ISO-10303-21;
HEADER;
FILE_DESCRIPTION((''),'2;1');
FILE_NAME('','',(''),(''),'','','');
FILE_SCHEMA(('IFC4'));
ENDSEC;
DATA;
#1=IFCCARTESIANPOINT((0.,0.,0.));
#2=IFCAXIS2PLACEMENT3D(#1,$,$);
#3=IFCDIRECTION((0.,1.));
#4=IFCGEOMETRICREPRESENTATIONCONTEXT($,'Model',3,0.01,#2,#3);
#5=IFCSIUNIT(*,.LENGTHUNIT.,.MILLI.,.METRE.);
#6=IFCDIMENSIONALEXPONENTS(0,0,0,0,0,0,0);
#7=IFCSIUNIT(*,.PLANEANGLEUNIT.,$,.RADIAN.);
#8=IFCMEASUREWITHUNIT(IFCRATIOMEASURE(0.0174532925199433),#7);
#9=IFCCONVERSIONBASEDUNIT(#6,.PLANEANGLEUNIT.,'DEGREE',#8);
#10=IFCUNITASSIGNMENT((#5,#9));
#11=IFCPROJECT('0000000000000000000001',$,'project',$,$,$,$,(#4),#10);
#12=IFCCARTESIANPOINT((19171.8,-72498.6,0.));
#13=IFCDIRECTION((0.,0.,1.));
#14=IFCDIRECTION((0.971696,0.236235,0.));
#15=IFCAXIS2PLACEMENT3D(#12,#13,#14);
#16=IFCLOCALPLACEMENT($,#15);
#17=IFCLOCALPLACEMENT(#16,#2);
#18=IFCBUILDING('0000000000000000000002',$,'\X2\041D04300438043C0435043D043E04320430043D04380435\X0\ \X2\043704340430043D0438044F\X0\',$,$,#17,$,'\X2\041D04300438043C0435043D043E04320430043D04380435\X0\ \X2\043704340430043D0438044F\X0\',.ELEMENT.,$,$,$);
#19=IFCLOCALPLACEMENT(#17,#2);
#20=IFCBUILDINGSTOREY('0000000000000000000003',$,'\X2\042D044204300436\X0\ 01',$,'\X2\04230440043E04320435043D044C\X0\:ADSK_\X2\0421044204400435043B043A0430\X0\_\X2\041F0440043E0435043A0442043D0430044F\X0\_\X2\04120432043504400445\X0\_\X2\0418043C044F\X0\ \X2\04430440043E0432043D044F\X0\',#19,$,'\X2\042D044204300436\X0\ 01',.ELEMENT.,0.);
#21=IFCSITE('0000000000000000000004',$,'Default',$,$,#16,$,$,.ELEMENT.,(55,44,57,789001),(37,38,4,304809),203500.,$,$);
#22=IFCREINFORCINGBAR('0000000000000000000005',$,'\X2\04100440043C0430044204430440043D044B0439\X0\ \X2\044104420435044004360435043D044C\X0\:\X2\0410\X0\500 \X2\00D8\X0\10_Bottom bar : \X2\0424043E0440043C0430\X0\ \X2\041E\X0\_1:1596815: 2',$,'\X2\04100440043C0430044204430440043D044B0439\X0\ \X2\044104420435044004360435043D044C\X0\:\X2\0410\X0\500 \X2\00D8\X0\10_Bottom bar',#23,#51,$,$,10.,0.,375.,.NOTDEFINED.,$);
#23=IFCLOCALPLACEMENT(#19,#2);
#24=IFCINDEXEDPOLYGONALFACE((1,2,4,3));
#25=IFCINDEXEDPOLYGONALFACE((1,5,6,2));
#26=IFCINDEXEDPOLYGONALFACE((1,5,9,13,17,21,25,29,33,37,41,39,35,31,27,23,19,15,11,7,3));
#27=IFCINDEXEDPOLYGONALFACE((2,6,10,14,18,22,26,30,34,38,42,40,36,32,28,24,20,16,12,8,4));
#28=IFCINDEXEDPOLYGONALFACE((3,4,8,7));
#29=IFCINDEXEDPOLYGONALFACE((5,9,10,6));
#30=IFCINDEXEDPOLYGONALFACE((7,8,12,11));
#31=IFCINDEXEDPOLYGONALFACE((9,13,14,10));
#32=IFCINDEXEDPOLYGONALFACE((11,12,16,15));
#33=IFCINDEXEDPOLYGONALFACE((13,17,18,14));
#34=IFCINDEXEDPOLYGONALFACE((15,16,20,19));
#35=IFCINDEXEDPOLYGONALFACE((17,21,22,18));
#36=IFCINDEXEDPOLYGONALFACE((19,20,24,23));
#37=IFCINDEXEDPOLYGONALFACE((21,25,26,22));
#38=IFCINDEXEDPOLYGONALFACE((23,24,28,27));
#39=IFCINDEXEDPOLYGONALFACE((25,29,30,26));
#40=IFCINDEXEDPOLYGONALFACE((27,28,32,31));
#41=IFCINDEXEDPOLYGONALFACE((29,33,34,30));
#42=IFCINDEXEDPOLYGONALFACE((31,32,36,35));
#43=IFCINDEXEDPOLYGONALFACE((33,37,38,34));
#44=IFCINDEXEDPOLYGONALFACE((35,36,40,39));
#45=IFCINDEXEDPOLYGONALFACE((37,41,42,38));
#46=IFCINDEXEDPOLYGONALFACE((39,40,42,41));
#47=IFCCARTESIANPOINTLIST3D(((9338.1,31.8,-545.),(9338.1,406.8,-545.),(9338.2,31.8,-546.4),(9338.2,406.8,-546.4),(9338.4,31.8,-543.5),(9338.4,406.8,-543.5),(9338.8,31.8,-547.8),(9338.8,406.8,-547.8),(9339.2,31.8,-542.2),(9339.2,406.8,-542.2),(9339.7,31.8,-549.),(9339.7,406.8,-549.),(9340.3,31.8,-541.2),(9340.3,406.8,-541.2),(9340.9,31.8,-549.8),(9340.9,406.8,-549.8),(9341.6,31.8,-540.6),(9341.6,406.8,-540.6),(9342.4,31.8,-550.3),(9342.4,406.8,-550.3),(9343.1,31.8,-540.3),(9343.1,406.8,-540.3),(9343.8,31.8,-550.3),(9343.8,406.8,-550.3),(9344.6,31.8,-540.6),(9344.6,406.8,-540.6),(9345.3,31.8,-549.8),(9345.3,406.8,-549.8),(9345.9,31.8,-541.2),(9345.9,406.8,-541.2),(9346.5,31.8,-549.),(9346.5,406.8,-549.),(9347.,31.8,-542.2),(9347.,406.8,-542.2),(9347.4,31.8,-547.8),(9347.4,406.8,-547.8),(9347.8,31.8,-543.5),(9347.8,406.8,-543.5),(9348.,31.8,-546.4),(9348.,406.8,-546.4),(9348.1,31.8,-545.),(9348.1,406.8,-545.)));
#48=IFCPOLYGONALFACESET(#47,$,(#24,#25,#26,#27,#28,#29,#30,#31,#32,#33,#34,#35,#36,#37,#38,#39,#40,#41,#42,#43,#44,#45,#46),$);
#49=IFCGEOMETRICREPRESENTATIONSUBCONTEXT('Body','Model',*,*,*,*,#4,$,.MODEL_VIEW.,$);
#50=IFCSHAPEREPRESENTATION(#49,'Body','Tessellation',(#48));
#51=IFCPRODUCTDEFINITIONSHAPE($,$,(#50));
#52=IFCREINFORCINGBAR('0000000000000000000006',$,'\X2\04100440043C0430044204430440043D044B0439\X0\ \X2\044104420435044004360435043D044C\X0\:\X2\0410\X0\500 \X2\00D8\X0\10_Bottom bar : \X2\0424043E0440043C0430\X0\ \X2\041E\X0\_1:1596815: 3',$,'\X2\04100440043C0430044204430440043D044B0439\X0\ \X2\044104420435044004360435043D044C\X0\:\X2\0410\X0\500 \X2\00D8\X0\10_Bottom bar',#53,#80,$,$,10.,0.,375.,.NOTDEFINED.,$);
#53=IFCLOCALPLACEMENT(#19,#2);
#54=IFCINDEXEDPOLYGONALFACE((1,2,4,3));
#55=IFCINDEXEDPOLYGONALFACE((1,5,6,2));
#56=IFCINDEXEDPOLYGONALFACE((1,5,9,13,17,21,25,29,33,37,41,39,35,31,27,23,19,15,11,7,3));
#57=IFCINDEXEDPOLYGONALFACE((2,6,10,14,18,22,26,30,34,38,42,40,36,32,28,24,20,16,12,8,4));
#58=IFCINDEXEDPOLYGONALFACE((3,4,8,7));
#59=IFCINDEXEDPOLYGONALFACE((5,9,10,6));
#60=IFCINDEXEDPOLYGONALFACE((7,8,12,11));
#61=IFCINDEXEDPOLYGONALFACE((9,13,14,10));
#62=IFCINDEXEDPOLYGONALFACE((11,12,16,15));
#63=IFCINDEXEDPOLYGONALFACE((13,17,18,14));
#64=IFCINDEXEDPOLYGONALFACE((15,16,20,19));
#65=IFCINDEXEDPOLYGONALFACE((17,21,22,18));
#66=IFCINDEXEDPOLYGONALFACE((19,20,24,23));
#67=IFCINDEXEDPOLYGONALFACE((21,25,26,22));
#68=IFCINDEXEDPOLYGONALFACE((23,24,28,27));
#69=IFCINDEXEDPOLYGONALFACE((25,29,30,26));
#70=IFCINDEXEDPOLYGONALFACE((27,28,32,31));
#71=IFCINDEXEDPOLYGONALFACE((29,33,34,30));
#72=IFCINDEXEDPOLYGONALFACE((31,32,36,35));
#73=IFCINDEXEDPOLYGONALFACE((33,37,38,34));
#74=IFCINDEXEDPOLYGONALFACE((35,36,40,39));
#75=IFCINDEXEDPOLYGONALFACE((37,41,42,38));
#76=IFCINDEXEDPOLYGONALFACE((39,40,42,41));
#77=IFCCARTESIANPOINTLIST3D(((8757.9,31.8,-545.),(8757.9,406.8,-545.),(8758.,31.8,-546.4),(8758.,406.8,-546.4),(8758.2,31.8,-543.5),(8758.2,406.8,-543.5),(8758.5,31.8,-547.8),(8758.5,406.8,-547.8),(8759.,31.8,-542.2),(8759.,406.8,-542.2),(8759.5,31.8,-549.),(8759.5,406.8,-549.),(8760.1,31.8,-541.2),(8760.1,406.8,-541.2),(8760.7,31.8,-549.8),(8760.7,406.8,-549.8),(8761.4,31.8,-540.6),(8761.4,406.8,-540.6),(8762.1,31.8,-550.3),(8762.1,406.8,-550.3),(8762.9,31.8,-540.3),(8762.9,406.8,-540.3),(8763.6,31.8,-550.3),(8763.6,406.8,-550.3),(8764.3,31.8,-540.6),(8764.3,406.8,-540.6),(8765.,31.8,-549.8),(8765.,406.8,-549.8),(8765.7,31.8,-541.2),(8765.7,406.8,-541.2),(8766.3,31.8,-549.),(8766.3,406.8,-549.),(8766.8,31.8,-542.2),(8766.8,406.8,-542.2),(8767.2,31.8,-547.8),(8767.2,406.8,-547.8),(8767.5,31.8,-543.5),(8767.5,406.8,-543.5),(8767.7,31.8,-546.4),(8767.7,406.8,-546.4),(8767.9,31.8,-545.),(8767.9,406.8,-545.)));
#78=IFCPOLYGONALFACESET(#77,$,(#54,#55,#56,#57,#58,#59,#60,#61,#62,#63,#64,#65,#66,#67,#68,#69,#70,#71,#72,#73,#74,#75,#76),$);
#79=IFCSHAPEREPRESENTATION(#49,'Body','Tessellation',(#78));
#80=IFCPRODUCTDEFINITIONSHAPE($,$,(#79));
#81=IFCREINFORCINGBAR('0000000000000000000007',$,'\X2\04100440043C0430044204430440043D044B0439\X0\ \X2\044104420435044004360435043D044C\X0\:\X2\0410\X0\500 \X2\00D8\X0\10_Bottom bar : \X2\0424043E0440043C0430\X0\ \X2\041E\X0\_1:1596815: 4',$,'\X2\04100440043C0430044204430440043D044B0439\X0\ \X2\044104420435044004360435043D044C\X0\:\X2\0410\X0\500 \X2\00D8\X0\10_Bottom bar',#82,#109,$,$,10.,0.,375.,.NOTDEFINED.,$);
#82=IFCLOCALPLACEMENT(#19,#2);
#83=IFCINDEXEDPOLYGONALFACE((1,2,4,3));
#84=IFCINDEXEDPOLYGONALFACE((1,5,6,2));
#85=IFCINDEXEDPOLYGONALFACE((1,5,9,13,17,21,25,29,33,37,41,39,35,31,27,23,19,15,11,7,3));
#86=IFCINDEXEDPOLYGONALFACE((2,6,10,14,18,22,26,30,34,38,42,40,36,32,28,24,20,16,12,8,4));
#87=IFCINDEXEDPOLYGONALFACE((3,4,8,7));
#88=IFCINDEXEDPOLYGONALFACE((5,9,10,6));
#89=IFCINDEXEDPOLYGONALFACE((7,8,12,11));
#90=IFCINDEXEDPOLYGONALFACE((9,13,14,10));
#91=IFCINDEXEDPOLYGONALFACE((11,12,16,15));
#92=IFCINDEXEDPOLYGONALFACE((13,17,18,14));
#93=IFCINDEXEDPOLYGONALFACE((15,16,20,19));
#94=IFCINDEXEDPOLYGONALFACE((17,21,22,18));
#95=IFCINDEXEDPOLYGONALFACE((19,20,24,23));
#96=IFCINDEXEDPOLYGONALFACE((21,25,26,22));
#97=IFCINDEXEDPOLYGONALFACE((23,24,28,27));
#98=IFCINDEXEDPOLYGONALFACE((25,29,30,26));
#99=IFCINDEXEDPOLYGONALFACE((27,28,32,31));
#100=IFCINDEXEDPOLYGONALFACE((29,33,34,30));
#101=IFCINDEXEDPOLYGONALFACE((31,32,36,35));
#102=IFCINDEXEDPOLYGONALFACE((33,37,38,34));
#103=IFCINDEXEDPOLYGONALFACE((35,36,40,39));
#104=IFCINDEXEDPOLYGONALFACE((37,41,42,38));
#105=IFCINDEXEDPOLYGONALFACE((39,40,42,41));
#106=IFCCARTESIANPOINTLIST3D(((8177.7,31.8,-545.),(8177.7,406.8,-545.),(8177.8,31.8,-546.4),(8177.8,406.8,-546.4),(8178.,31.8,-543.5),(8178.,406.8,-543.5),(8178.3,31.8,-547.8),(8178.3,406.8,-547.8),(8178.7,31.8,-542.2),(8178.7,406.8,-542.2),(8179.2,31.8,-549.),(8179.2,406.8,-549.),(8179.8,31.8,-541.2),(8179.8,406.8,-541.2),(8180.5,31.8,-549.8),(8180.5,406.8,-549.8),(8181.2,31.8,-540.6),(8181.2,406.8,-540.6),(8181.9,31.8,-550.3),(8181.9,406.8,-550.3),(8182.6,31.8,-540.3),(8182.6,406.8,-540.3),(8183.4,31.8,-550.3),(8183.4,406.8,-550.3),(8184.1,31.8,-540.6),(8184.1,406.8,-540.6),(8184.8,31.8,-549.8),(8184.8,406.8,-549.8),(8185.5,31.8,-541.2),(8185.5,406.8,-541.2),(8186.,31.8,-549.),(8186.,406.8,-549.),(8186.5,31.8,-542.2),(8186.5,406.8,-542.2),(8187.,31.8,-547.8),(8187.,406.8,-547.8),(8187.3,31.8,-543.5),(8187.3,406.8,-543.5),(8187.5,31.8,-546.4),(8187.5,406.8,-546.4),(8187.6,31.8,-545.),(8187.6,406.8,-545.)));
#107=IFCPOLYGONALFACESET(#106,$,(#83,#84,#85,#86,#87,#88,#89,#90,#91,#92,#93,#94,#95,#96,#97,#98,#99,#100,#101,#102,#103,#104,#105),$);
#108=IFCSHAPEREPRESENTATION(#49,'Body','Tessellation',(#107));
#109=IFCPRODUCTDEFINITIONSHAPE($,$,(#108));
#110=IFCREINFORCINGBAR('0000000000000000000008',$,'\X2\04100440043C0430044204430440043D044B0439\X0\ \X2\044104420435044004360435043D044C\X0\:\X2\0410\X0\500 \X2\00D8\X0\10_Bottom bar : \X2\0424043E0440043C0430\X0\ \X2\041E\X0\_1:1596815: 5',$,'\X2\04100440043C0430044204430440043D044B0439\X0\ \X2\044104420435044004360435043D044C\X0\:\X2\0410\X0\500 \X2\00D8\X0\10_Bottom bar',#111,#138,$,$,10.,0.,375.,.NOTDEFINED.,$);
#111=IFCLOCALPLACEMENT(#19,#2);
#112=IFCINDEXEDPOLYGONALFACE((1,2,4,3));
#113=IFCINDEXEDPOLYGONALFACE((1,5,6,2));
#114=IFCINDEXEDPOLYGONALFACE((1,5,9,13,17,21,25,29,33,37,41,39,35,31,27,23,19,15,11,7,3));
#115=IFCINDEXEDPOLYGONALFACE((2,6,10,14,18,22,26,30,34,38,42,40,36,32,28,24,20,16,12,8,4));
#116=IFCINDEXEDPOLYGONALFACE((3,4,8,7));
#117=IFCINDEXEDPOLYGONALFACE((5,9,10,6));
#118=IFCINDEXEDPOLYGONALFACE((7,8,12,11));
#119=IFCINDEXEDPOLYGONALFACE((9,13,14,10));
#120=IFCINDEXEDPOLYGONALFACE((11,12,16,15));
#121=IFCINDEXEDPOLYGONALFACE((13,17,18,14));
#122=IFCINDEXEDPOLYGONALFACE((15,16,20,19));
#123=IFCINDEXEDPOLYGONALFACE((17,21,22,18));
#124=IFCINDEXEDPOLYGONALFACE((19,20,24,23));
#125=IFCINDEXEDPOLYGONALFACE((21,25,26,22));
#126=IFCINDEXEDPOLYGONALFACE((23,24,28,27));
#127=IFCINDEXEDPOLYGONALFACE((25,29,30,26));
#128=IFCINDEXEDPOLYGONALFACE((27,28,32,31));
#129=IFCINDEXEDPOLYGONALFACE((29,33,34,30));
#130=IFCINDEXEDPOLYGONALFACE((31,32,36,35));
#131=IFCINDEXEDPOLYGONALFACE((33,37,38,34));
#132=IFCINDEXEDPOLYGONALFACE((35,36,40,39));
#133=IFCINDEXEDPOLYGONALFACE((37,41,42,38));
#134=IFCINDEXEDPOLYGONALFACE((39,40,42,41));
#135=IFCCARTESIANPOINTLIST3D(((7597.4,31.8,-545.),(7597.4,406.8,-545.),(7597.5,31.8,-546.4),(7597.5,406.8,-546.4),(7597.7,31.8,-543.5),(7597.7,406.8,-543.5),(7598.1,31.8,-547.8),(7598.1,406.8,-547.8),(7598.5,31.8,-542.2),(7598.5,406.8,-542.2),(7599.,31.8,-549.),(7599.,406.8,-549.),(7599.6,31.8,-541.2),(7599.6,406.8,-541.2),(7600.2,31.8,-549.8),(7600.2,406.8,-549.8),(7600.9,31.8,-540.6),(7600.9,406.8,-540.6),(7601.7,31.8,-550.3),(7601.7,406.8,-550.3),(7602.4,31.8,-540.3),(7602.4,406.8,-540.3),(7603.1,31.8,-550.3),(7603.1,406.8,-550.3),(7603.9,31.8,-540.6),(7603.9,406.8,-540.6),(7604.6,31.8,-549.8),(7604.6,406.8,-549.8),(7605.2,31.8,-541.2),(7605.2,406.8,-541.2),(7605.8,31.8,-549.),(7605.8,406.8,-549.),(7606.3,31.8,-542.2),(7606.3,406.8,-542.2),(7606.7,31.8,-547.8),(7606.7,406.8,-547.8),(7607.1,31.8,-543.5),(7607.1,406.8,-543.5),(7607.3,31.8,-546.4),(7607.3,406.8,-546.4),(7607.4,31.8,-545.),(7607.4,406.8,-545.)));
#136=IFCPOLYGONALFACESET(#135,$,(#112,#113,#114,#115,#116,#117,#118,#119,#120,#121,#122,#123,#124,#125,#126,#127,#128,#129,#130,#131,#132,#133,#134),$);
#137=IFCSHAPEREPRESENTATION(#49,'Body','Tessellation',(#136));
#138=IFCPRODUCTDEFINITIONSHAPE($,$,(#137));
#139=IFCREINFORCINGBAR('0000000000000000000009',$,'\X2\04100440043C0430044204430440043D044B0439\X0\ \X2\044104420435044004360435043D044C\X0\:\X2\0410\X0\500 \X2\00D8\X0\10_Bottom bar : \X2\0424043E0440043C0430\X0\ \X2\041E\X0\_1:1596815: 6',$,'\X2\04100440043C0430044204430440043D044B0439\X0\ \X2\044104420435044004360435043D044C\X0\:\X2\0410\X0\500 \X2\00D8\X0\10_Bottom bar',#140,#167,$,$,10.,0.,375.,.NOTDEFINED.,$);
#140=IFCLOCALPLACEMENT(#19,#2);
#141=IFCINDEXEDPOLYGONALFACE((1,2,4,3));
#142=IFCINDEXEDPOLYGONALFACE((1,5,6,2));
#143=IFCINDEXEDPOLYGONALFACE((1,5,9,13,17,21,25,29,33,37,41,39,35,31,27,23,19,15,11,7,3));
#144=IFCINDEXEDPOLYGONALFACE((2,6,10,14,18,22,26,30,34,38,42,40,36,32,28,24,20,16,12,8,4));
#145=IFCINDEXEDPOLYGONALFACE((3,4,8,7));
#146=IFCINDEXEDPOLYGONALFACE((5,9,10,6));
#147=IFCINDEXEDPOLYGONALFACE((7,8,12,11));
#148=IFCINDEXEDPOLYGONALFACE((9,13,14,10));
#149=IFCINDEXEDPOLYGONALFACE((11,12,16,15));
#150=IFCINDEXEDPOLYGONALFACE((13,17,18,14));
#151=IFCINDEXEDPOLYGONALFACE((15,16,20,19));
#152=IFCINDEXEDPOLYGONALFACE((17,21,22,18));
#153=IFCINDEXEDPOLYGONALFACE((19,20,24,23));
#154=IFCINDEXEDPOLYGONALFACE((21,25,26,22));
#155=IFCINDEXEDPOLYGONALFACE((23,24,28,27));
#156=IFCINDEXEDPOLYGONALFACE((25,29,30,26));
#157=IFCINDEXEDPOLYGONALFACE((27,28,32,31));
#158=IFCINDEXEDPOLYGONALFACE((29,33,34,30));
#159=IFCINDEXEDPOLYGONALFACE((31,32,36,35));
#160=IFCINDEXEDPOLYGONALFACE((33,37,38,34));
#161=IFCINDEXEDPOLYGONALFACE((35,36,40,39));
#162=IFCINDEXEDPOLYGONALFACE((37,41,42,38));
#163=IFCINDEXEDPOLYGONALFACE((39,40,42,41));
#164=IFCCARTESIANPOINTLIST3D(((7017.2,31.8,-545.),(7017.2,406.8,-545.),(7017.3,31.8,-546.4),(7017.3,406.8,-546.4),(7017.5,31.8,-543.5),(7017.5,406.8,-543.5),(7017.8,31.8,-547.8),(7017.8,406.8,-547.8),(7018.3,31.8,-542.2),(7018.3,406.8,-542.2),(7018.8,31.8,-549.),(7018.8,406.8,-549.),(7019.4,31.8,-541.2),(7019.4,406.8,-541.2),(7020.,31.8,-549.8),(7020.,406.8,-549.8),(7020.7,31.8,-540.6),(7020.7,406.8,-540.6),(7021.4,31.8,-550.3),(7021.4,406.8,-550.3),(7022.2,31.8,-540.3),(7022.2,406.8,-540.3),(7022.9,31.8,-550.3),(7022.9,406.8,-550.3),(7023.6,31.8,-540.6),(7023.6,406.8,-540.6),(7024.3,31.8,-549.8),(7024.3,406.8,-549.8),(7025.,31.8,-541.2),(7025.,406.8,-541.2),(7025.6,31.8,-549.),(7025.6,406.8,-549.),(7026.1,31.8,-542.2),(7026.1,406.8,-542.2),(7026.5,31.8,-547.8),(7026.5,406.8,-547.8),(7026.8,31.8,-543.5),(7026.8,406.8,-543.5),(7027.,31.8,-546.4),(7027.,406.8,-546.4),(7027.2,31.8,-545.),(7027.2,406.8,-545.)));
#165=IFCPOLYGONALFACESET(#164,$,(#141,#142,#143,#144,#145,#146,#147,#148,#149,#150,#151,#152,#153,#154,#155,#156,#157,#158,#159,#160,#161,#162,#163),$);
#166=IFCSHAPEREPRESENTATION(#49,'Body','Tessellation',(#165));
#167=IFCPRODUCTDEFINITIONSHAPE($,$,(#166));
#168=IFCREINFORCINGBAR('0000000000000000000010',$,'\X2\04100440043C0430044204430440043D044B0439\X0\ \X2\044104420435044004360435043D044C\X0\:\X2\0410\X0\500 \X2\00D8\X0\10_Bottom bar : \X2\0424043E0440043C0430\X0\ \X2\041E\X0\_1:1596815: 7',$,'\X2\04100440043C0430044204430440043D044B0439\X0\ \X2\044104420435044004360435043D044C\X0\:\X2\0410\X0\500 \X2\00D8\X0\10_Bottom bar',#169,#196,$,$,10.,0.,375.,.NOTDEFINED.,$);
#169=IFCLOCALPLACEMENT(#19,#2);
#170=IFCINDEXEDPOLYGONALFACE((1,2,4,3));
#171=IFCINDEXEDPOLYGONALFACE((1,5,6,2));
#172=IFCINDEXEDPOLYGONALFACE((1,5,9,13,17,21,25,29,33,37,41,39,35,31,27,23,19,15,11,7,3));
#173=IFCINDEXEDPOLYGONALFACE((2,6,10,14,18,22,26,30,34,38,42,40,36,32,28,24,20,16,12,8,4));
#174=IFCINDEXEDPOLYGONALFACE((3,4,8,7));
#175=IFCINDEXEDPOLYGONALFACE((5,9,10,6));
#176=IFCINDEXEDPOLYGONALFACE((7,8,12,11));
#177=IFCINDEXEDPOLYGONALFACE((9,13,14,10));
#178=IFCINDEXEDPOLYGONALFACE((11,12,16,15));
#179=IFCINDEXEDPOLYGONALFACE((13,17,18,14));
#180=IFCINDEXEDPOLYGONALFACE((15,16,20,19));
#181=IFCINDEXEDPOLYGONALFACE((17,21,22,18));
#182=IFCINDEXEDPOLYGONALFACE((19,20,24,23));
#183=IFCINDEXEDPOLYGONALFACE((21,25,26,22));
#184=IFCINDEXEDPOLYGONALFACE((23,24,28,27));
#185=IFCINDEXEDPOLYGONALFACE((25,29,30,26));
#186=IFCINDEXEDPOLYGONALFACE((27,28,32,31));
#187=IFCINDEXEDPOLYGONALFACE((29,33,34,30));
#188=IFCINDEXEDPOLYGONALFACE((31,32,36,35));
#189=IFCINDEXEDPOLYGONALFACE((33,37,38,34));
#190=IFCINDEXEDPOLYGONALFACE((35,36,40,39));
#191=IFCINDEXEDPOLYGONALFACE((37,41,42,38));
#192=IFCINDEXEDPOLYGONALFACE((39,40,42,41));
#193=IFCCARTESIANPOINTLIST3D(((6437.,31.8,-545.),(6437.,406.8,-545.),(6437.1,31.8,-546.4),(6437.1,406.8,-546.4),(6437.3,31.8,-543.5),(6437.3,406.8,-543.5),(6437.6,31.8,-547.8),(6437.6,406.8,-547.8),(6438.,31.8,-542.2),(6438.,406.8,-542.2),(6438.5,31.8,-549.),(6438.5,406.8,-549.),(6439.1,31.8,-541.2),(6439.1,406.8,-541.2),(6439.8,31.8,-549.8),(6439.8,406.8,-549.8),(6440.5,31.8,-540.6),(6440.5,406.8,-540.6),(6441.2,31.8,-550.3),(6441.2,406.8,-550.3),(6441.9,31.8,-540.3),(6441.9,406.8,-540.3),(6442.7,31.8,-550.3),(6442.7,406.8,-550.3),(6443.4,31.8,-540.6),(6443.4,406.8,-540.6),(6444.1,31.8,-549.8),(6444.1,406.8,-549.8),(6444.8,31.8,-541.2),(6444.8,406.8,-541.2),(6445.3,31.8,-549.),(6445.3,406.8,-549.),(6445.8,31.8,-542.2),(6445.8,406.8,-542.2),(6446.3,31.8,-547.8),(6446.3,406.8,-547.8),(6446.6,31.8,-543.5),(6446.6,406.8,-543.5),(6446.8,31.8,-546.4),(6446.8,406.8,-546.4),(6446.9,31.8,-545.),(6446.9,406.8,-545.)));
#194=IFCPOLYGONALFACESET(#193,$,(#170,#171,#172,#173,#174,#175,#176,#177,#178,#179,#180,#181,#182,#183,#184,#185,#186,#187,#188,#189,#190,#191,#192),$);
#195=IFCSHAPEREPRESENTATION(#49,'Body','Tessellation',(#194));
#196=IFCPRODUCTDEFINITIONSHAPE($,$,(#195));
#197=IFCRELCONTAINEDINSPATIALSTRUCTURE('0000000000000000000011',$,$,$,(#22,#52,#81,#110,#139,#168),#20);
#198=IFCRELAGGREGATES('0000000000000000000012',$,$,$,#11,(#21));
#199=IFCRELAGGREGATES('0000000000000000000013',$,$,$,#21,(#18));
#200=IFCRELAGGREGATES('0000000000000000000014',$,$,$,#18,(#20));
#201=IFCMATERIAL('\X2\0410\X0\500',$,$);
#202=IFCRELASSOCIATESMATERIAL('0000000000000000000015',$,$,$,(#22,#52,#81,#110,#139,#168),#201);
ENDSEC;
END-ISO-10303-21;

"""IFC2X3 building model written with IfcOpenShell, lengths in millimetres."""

from ifc_helpers import new_model, entity, si_unit, converted_unit, direction, frame, origin, place, context, subcontext, project, spatial, material, element, save


model = new_model("IFC2X3")

# Units and contexts
model_context = context("Model", 3, precision=0.01, world=origin(), true_north=direction((0.0, 1.0)))
body_context = subcontext(model_context, "Body", "Model", "MODEL_VIEW")
ifc_project = project(units=[si_unit("LENGTHUNIT", "METRE", prefix="MILLI"), converted_unit("PLANEANGLEUNIT", "DEGREE", entity("IfcRatioMeasure", 0.0174532925199433), si_unit("PLANEANGLEUNIT", "RADIAN"), dimensions=[0, 0, 0, 0, 0, 0, 0])], contexts=[model_context])

# Site, building, storey
site_placement = place(None, frame((19171.8, -72498.6, 0.0), z_axis=(0.0, 0.0, 1.0), x_axis=(0.971696, 0.236235, 0.0)))
site = spatial("IfcSite", under=ifc_project, at=site_placement, Name="Default", CompositionType="ELEMENT", RefLatitude=(55, 44, 57, 789001), RefLongitude=(37, 38, 4, 304809), RefElevation=203500.0)
building_placement = place(site_placement, origin())
building = spatial("IfcBuilding", under=site, at=building_placement, Name="Наименование здания", LongName="Наименование здания", CompositionType="ELEMENT")
storey_placement = place(building_placement, origin())
storey = spatial("IfcBuildingStorey", under=building, at=storey_placement, Name="Этаж 01", ObjectType="Уровень:ADSK_Стрелка_Проектная_Вверх_Имя уровня", LongName="Этаж 01", CompositionType="ELEMENT", Elevation=0.0)

# Reinforcing bars
ifc_material = material(Name="А500")
placement = place(storey_placement, origin())
element("IfcReinforcingBar", 1, at=placement, inside=storey, material=ifc_material, Name="Арматурный стержень:А500 Ø10_Bottom bar : Форма О_1:1596815: 2", ObjectType="Арматурный стержень:А500 Ø10_Bottom bar", BarLength=375.0, BarRole="NOTDEFINED", CrossSectionArea=0.0, NominalDiameter=10.0, context=body_context, shape_type="AdvancedSweptSolid", body=[
    entity("IfcSweptDiskSolid", entity("IfcCompositeCurve", [entity("IfcCompositeCurveSegment", "CONTINUOUS", True, entity("IfcPolyline", [entity("IfcCartesianPoint", [9343.1, 31.8, -545.3]), entity("IfcCartesianPoint", [9343.1, 406.8, -545.3])]))], False), 5.0, None, 0.0, 1.0),
])
element("IfcReinforcingBar", 2, at=placement, inside=storey, material=ifc_material, Name="Арматурный стержень:А500 Ø10_Bottom bar : Форма О_1:1596815: 3", ObjectType="Арматурный стержень:А500 Ø10_Bottom bar", BarLength=375.0, BarRole="NOTDEFINED", CrossSectionArea=0.0, NominalDiameter=10.0, context=body_context, shape_type="AdvancedSweptSolid", body=[
    entity("IfcSweptDiskSolid", entity("IfcCompositeCurve", [entity("IfcCompositeCurveSegment", "CONTINUOUS", True, entity("IfcPolyline", [entity("IfcCartesianPoint", [8762.9, 31.8, -545.3]), entity("IfcCartesianPoint", [8762.9, 406.8, -545.3])]))], False), 5.0, None, 0.0, 1.0),
])
element("IfcReinforcingBar", 3, at=placement, inside=storey, material=ifc_material, Name="Арматурный стержень:А500 Ø10_Bottom bar : Форма О_1:1596815: 4", ObjectType="Арматурный стержень:А500 Ø10_Bottom bar", BarLength=375.0, BarRole="NOTDEFINED", CrossSectionArea=0.0, NominalDiameter=10.0, context=body_context, shape_type="AdvancedSweptSolid", body=[
    entity("IfcSweptDiskSolid", entity("IfcCompositeCurve", [entity("IfcCompositeCurveSegment", "CONTINUOUS", True, entity("IfcPolyline", [entity("IfcCartesianPoint", [8182.6, 31.8, -545.3]), entity("IfcCartesianPoint", [8182.6, 406.8, -545.3])]))], False), 5.0, None, 0.0, 1.0),
])
element("IfcReinforcingBar", 4, at=placement, inside=storey, material=ifc_material, Name="Арматурный стержень:А500 Ø10_Bottom bar : Форма О_1:1596815: 5", ObjectType="Арматурный стержень:А500 Ø10_Bottom bar", BarLength=375.0, BarRole="NOTDEFINED", CrossSectionArea=0.0, NominalDiameter=10.0, context=body_context, shape_type="AdvancedSweptSolid", body=[
    entity("IfcSweptDiskSolid", entity("IfcCompositeCurve", [entity("IfcCompositeCurveSegment", "CONTINUOUS", True, entity("IfcPolyline", [entity("IfcCartesianPoint", [7602.4, 31.8, -545.3]), entity("IfcCartesianPoint", [7602.4, 406.8, -545.3])]))], False), 5.0, None, 0.0, 1.0),
])
element("IfcReinforcingBar", 5, at=placement, inside=storey, material=ifc_material, Name="Арматурный стержень:А500 Ø10_Bottom bar : Форма О_1:1596815: 6", ObjectType="Арматурный стержень:А500 Ø10_Bottom bar", BarLength=375.0, BarRole="NOTDEFINED", CrossSectionArea=0.0, NominalDiameter=10.0, context=body_context, shape_type="AdvancedSweptSolid", body=[
    entity("IfcSweptDiskSolid", entity("IfcCompositeCurve", [entity("IfcCompositeCurveSegment", "CONTINUOUS", True, entity("IfcPolyline", [entity("IfcCartesianPoint", [7022.2, 31.8, -545.3]), entity("IfcCartesianPoint", [7022.2, 406.8, -545.3])]))], False), 5.0, None, 0.0, 1.0),
])
element("IfcReinforcingBar", 6, at=placement, inside=storey, material=ifc_material, Name="Арматурный стержень:А500 Ø10_Bottom bar : Форма О_1:1596815: 7", ObjectType="Арматурный стержень:А500 Ø10_Bottom bar", BarLength=375.0, BarRole="NOTDEFINED", CrossSectionArea=0.0, NominalDiameter=10.0, context=body_context, shape_type="AdvancedSweptSolid", body=[
    entity("IfcSweptDiskSolid", entity("IfcCompositeCurve", [entity("IfcCompositeCurveSegment", "CONTINUOUS", True, entity("IfcPolyline", [entity("IfcCartesianPoint", [6441.9, 31.8, -545.3]), entity("IfcCartesianPoint", [6441.9, 406.8, -545.3])]))], False), 5.0, None, 0.0, 1.0),
])

save(model, "model.ifc")
